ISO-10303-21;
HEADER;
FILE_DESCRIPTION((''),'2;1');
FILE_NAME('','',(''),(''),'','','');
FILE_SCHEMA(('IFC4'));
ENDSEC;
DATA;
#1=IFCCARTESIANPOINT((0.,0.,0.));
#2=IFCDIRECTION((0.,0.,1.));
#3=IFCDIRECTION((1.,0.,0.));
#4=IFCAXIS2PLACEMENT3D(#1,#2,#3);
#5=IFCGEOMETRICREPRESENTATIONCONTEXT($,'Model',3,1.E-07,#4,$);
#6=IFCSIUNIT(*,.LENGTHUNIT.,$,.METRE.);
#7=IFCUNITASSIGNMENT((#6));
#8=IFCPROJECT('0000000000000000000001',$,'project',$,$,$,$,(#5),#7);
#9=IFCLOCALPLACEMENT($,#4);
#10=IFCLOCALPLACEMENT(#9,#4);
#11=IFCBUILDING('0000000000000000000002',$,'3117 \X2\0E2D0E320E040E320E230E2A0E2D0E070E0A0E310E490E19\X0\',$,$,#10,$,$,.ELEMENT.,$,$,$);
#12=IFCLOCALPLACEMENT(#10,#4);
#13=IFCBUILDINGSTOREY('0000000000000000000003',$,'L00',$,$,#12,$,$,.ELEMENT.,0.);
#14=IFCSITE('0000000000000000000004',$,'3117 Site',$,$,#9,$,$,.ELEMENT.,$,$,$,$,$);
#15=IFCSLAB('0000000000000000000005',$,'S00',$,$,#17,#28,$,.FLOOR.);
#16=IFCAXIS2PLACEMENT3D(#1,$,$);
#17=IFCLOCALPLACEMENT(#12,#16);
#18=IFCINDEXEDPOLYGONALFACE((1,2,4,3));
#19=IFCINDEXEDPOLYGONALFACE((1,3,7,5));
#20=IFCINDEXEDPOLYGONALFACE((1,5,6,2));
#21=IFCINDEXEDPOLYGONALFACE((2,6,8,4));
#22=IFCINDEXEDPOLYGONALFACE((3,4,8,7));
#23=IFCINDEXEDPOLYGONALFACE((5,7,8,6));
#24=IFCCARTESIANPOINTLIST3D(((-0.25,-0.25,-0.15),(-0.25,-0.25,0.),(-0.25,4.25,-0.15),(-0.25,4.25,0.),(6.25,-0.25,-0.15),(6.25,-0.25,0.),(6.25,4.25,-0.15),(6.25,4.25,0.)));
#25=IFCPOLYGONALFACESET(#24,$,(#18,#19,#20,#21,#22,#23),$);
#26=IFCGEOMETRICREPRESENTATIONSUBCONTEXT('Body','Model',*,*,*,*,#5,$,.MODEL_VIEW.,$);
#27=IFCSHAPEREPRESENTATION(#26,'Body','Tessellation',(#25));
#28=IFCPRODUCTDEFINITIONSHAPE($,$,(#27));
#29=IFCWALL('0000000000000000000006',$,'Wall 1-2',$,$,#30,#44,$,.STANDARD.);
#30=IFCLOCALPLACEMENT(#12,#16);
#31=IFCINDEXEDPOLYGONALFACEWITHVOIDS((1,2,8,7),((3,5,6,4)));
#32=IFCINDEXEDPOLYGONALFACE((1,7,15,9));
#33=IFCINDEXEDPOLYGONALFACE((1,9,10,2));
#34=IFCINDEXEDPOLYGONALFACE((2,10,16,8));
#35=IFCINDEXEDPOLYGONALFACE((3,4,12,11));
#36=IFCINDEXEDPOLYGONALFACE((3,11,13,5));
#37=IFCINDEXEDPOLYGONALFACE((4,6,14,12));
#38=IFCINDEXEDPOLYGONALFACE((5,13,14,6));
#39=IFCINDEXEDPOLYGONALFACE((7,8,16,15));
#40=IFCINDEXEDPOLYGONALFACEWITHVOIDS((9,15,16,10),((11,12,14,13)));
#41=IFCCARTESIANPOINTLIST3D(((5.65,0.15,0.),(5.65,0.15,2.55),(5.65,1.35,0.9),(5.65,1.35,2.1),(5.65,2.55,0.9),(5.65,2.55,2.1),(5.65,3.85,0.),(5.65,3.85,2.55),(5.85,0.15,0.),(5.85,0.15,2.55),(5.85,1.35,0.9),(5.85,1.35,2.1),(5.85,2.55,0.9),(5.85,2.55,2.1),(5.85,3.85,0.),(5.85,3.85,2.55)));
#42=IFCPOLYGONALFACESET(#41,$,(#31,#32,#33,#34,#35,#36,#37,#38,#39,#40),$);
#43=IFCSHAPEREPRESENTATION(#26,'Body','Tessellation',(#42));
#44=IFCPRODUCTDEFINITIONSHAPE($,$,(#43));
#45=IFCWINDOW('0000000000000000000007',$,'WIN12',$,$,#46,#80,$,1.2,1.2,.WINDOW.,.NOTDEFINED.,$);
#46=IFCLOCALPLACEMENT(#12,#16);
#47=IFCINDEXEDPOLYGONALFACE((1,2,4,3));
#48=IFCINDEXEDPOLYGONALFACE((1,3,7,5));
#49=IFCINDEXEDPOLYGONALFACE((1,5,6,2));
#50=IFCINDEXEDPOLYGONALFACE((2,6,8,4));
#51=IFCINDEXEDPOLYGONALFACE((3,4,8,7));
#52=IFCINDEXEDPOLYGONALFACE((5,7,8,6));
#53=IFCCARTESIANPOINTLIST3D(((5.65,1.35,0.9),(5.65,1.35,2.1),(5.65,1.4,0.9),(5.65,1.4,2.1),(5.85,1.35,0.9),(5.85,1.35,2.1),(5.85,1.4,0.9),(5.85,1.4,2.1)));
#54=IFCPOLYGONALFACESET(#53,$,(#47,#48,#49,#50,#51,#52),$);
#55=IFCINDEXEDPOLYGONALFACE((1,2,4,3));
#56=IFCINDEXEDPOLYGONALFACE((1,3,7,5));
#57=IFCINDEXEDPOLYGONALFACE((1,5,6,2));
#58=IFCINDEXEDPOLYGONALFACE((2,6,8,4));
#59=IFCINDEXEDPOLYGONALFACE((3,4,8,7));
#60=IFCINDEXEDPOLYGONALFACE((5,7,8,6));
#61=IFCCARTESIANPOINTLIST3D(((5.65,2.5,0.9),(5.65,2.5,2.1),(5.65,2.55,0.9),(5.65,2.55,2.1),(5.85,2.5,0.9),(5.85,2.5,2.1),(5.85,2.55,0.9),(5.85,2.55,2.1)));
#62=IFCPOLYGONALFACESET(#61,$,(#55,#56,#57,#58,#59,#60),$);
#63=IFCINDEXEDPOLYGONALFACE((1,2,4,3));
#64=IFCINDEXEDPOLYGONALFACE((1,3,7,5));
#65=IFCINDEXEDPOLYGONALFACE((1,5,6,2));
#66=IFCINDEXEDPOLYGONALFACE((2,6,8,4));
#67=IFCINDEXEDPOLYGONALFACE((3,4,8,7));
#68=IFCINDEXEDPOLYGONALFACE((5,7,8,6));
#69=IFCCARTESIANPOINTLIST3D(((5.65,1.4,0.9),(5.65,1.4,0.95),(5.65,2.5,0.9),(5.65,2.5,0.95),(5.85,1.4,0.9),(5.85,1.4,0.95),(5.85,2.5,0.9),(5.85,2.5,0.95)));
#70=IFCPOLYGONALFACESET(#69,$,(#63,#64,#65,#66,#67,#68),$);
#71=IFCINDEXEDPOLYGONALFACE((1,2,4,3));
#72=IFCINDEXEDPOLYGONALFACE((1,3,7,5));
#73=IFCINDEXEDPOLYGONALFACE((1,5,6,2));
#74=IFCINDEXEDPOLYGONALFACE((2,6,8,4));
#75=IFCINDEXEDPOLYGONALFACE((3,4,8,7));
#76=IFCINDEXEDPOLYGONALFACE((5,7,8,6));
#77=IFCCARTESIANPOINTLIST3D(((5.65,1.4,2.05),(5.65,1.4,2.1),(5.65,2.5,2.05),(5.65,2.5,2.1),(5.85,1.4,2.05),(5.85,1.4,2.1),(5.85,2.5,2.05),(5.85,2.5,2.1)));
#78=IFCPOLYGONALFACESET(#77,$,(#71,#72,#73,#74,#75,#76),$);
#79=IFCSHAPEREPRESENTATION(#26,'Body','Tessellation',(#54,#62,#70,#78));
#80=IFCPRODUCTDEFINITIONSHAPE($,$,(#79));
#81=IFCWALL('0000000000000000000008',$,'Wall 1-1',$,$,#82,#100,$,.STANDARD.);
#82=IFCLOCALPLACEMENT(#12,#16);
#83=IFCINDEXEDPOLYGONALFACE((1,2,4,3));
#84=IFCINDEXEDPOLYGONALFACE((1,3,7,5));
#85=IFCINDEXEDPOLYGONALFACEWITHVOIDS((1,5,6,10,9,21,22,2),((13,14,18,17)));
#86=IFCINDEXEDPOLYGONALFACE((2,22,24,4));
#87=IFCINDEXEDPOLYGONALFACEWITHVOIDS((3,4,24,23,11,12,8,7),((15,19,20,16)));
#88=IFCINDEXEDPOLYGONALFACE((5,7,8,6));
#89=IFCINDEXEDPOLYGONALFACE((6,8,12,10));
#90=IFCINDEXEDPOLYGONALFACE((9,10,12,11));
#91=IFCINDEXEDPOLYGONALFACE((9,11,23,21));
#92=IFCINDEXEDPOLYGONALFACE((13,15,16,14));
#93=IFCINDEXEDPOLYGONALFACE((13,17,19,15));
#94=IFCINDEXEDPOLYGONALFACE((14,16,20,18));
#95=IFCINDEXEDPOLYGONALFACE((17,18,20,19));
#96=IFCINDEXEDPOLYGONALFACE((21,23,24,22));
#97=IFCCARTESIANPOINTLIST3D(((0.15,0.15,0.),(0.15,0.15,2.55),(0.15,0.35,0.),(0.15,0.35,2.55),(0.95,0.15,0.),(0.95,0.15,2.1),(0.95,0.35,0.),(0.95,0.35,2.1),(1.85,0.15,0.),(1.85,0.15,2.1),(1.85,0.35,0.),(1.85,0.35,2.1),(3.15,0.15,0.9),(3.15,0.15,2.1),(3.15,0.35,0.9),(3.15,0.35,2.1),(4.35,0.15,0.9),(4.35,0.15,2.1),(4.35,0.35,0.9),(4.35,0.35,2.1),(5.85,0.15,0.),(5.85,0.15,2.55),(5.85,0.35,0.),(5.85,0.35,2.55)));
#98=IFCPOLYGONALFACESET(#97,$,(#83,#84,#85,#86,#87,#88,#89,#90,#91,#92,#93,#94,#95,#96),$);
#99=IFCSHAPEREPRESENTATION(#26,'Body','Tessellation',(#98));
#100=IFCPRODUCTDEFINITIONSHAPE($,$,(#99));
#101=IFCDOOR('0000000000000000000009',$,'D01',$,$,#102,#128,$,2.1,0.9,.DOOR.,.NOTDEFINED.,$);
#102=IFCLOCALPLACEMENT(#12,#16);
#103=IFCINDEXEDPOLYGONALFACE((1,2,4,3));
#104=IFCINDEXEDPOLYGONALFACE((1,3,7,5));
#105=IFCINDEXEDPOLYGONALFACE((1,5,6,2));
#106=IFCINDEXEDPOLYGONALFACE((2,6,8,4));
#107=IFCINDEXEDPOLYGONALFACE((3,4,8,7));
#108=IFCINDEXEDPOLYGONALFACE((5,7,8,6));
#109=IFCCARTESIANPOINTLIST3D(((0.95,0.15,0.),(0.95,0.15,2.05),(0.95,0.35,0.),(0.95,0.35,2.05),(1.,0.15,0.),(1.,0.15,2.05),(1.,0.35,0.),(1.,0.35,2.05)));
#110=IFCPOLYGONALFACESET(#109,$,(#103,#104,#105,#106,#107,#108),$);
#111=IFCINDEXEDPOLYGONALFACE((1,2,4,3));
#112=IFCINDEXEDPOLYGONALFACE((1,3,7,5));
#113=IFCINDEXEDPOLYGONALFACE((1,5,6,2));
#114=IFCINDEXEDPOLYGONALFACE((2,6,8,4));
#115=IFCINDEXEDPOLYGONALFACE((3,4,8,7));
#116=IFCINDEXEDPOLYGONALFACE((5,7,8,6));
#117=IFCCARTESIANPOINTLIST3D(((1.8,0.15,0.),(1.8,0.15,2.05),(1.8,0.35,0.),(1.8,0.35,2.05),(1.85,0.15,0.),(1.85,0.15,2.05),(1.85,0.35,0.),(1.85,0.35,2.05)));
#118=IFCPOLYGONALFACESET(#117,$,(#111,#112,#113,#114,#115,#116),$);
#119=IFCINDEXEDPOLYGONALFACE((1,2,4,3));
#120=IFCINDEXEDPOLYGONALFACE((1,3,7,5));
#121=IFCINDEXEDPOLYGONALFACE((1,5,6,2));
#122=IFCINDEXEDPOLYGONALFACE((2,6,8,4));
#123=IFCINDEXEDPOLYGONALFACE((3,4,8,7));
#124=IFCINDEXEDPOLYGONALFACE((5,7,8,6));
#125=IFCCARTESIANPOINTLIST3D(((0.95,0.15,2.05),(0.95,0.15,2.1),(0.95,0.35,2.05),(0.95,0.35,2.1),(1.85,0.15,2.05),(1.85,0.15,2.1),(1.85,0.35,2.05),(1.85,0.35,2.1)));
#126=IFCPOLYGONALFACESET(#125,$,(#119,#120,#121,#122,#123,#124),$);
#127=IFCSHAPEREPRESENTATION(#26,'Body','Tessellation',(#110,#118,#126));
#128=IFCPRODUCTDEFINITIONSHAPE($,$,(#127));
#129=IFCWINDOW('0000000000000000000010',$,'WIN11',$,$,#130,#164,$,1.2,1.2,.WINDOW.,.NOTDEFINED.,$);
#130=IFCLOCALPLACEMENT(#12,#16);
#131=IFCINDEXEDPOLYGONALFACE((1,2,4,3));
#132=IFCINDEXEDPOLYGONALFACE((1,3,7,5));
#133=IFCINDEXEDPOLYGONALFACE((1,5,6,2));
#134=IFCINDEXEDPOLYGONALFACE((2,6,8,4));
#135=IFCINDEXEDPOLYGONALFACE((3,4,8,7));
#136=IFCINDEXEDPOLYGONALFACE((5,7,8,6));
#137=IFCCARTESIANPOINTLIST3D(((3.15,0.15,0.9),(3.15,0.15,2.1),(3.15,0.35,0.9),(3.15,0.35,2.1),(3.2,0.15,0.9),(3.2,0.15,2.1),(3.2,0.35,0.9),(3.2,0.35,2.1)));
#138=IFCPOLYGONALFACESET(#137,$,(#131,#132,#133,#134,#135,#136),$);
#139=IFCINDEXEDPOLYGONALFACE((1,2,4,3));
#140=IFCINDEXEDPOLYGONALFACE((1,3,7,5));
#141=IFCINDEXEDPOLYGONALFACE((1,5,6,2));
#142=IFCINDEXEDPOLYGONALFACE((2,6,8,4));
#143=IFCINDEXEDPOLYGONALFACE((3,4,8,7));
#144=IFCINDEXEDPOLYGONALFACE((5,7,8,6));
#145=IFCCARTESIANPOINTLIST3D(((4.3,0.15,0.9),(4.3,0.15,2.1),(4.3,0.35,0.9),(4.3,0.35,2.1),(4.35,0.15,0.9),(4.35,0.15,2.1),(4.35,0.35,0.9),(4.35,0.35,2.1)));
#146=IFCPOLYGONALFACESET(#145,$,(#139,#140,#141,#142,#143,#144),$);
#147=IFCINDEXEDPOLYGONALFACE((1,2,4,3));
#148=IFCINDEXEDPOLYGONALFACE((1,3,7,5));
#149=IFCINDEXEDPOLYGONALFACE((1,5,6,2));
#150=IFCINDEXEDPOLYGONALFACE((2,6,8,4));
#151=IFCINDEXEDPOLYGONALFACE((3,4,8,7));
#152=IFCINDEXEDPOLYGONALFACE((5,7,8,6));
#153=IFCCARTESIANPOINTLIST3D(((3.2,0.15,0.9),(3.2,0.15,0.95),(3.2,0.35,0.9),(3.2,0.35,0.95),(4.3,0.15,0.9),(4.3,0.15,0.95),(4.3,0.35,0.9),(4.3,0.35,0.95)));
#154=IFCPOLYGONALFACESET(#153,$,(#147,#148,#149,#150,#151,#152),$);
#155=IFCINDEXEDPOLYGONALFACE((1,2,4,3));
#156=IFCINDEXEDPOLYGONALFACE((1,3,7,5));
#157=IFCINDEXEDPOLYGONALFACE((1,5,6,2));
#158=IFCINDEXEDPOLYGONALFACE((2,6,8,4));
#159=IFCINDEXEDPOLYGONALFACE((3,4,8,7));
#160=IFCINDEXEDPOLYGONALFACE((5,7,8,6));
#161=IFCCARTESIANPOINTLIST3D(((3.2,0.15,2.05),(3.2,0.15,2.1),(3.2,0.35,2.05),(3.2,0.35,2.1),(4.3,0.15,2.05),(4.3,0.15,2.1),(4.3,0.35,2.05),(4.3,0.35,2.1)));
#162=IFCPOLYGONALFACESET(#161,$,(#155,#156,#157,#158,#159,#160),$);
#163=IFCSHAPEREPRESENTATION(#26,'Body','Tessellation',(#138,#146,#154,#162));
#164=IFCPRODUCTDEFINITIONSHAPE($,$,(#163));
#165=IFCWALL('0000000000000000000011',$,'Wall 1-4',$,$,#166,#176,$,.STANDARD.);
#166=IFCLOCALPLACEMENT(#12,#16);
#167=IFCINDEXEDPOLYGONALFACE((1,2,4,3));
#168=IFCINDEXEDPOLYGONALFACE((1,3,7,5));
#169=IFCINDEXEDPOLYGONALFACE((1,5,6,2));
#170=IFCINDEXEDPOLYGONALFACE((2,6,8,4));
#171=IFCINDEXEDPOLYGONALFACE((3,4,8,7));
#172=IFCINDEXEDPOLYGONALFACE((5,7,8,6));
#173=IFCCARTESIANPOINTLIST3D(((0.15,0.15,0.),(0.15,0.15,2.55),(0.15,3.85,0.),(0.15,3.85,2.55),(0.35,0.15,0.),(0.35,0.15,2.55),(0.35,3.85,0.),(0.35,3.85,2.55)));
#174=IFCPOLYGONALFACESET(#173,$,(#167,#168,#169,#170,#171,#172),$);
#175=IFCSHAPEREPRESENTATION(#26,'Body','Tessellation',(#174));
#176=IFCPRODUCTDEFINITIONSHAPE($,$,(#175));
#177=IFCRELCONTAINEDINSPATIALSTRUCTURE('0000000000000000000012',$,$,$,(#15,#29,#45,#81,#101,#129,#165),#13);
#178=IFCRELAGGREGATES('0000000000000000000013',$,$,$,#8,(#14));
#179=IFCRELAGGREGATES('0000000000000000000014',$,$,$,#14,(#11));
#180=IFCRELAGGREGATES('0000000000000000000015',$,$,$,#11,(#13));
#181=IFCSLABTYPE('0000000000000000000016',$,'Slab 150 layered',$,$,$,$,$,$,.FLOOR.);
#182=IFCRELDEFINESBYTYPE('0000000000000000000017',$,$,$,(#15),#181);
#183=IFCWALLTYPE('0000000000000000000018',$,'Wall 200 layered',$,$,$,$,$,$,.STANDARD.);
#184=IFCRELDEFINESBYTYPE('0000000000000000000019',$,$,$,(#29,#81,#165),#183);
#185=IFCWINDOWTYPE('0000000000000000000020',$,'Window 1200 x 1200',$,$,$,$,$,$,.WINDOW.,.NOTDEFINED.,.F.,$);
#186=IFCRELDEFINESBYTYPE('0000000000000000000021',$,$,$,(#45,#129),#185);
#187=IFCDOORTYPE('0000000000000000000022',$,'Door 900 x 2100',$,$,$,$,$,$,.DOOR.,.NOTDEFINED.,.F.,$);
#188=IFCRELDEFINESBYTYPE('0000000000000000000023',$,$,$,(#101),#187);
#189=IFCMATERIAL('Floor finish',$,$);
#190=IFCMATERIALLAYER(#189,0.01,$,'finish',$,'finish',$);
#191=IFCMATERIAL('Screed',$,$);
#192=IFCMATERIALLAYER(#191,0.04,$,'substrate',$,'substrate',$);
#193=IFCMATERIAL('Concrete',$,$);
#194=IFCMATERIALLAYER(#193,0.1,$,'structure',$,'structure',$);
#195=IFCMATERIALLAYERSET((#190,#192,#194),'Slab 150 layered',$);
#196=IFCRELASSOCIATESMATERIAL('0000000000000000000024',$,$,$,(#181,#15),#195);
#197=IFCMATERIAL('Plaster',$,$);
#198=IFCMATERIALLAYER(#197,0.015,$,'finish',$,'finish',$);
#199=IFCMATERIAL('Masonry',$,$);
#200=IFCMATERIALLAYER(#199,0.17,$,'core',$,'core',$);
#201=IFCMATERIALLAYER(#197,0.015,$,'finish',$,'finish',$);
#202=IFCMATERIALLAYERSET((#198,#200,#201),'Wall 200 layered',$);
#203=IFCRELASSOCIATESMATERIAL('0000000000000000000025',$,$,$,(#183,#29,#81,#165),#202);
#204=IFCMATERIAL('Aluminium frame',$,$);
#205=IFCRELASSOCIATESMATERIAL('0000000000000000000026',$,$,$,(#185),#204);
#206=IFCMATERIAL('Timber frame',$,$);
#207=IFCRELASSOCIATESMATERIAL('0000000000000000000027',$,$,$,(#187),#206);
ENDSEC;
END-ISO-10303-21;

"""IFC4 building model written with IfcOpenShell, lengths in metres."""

from ifc_helpers import new_model, si_unit, frame, origin_with_axes, place, context, subcontext, project, spatial, polyline, outline, extrude, material, layer, layer_set, layer_usage, type_object, element, fill, save


model = new_model("IFC4")

# Units and contexts
model_context = context("Model", 3, precision=1e-07, world=origin_with_axes())
body_context = subcontext(model_context, "Body", "Model", "MODEL_VIEW")
ifc_project = project(units=[si_unit("LENGTHUNIT", "METRE")], contexts=[model_context])

# Site, building, storey
site_placement = place(None, origin_with_axes())
site = spatial("IfcSite", under=ifc_project, at=site_placement, Name="3117 Site", CompositionType="ELEMENT")
building_placement = place(site_placement, origin_with_axes())
building = spatial("IfcBuilding", under=site, at=building_placement, Name="3117 อาคารสองชั้น", CompositionType="ELEMENT")
storey_placement = place(building_placement, origin_with_axes())
storey = spatial("IfcBuildingStorey", under=building, at=storey_placement, Name="L00", CompositionType="ELEMENT", Elevation=0.0)

# Shared definitions
ifc_material_1 = material(Name="Concrete")

# Slab
ifc_material_2 = material(Name="Floor finish")
ifc_layer_1 = layer(ifc_material_2, 0.01, Name="finish", Category="finish")
ifc_material_3 = material(Name="Screed")
ifc_layer_2 = layer(ifc_material_3, 0.04, Name="substrate", Category="substrate")
ifc_layer_3 = layer(ifc_material_1, 0.1, Name="structure", Category="structure")
ifc_layer_set_1 = layer_set([ifc_layer_1, ifc_layer_2, ifc_layer_3], Name="Slab 150 layered")
ifc_layer_usage_1 = layer_usage(ifc_layer_set_1, "AXIS3", "NEGATIVE", 0.15)
slab_type = type_object("IfcSlabType", Name="Slab 150 layered", PredefinedType="FLOOR", material=ifc_layer_set_1)
slab_placement = place(storey_placement, frame((0.0, 0.0, -0.15), z_axis=(0.0, 0.0, 1.0), x_axis=(1.0, 0.0, 0.0)))
element("IfcSlab", 1, at=slab_placement, inside=storey, type_object=slab_type, material=ifc_layer_usage_1, Name="S00", PredefinedType="FLOOR", context=body_context, shape_type="SweptSolid", body=[
    extrude(outline(polyline([(-0.25, -0.25), (6.25, -0.25), (6.25, 4.25), (-0.25, 4.25), (-0.25, -0.25)])), origin_with_axes(), (0.0, 0.0, 1.0), 0.15),
])

# Wall, opening, window
ifc_material_4 = material(Name="Plaster")
ifc_layer_4 = layer(ifc_material_4, 0.015, Name="finish", Category="finish")
ifc_material_5 = material(Name="Masonry")
ifc_layer_5 = layer(ifc_material_5, 0.17, Name="core", Category="core")
ifc_layer_6 = layer(ifc_material_4, 0.015, Name="finish", Category="finish")
ifc_layer_set_2 = layer_set([ifc_layer_4, ifc_layer_5, ifc_layer_6], Name="Wall 200 layered")
ifc_layer_usage_2 = layer_usage(ifc_layer_set_2, "AXIS2", "POSITIVE", 0.0)
wall_type = type_object("IfcWallType", Name="Wall 200 layered", PredefinedType="STANDARD", material=ifc_layer_set_2)
wall_1_placement = place(storey_placement, frame((5.85, 0.15, 0.0), z_axis=(0.0, 0.0, 1.0), x_axis=(0.0, 1.0, 0.0)))
wall_1 = element("IfcWall", 2, at=wall_1_placement, inside=storey, type_object=wall_type, material=ifc_layer_usage_2, Name="Wall 1-2", PredefinedType="STANDARD", context=body_context, shape_type="SweptSolid", body=[
    extrude(outline(polyline([(0.0, 0.0), (3.7, 0.0), (3.7, 0.2), (0.0, 0.2), (0.0, 0.0)])), origin_with_axes(), (0.0, 0.0, 1.0), 2.55),
])
opening_1_placement = place(wall_1_placement, frame((1.2, 0.0, 0.9), z_axis=(0.0, 0.0, 1.0), x_axis=(1.0, 0.0, 0.0)))
opening_1 = element("IfcOpeningElement", 3, at=opening_1_placement, cuts=wall_1, PredefinedType="OPENING", context=body_context, shape_type="SweptSolid", body=[
    extrude(outline(polyline([(0.0, 0.0), (1.2, 0.0), (1.2, 0.2), (0.0, 0.2), (0.0, 0.0)])), origin_with_axes(), (0.0, 0.0, 1.0), 1.2),
])
ifc_material_6 = material(Name="Aluminium frame")
window_type = type_object("IfcWindowType", Name="Window 1200 x 1200", ParameterTakesPrecedence=False, PartitioningType="NOTDEFINED", PredefinedType="WINDOW", material=ifc_material_6)
window_1_placement = place(opening_1_placement, frame((0.0, 0.0, 0.0), z_axis=(0.0, 0.0, 1.0), x_axis=(1.0, 0.0, 0.0)))
window_1 = element("IfcWindow", 4, at=window_1_placement, inside=storey, type_object=window_type, Name="WIN12", OverallHeight=1.2, OverallWidth=1.2, PartitioningType="NOTDEFINED", PredefinedType="WINDOW", context=body_context, shape_type="SweptSolid", body=[
    extrude(outline(polyline([(0.0, 0.0), (0.05, 0.0), (0.05, 0.2), (0.0, 0.2), (0.0, 0.0)])), origin_with_axes(), (0.0, 0.0, 1.0), 1.2),
    extrude(outline(polyline([(0.0, 0.0), (0.05, 0.0), (0.05, 0.2), (0.0, 0.2), (0.0, 0.0)])), frame((1.15, 0.0, 0.0), z_axis=(0.0, 0.0, 1.0), x_axis=(1.0, 0.0, 0.0)), (0.0, 0.0, 1.0), 1.2),
    extrude(outline(polyline([(0.0, 0.0), (1.1, 0.0), (1.1, 0.2), (0.0, 0.2), (0.0, 0.0)])), frame((0.05, 0.0, 0.0), z_axis=(0.0, 0.0, 1.0), x_axis=(1.0, 0.0, 0.0)), (0.0, 0.0, 1.0), 0.05),
    extrude(outline(polyline([(0.0, 0.0), (1.1, 0.0), (1.1, 0.2), (0.0, 0.2), (0.0, 0.0)])), frame((0.05, 0.0, 1.15), z_axis=(0.0, 0.0, 1.0), x_axis=(1.0, 0.0, 0.0)), (0.0, 0.0, 1.0), 0.05),
])
fill(opening_1, window_1)

# Wall, openings, door, window
ifc_layer_usage_3 = layer_usage(ifc_layer_set_2, "AXIS2", "POSITIVE", 0.0)
wall_2_placement = place(storey_placement, frame((0.15, 0.15, 0.0), z_axis=(0.0, 0.0, 1.0), x_axis=(1.0, 0.0, 0.0)))
wall_2 = element("IfcWall", 5, at=wall_2_placement, inside=storey, type_object=wall_type, material=ifc_layer_usage_3, Name="Wall 1-1", PredefinedType="STANDARD", context=body_context, shape_type="SweptSolid", body=[
    extrude(outline(polyline([(0.0, 0.0), (5.7, 0.0), (5.7, 0.2), (0.0, 0.2), (0.0, 0.0)])), origin_with_axes(), (0.0, 0.0, 1.0), 2.55),
])
opening_2_placement = place(wall_2_placement, frame((0.8, 0.0, 0.0), z_axis=(0.0, 0.0, 1.0), x_axis=(1.0, 0.0, 0.0)))
opening_2 = element("IfcOpeningElement", 6, at=opening_2_placement, cuts=wall_2, PredefinedType="OPENING", context=body_context, shape_type="SweptSolid", body=[
    extrude(outline(polyline([(0.0, 0.0), (0.9, 0.0), (0.9, 0.2), (0.0, 0.2), (0.0, 0.0)])), origin_with_axes(), (0.0, 0.0, 1.0), 2.1),
])
opening_3_placement = place(wall_2_placement, frame((3.0, 0.0, 0.9), z_axis=(0.0, 0.0, 1.0), x_axis=(1.0, 0.0, 0.0)))
opening_3 = element("IfcOpeningElement", 7, at=opening_3_placement, cuts=wall_2, PredefinedType="OPENING", context=body_context, shape_type="SweptSolid", body=[
    extrude(outline(polyline([(0.0, 0.0), (1.2, 0.0), (1.2, 0.2), (0.0, 0.2), (0.0, 0.0)])), origin_with_axes(), (0.0, 0.0, 1.0), 1.2),
])
ifc_material_7 = material(Name="Timber frame")
door_type = type_object("IfcDoorType", Name="Door 900 x 2100", OperationType="NOTDEFINED", ParameterTakesPrecedence=False, PredefinedType="DOOR", material=ifc_material_7)
door_placement = place(opening_2_placement, frame((0.0, 0.0, 0.0), z_axis=(0.0, 0.0, 1.0), x_axis=(1.0, 0.0, 0.0)))
door = element("IfcDoor", 8, at=door_placement, inside=storey, type_object=door_type, Name="D01", OperationType="NOTDEFINED", OverallHeight=2.1, OverallWidth=0.9, PredefinedType="DOOR", context=body_context, shape_type="SweptSolid", body=[
    extrude(outline(polyline([(0.0, 0.0), (0.05, 0.0), (0.05, 0.2), (0.0, 0.2), (0.0, 0.0)])), origin_with_axes(), (0.0, 0.0, 1.0), 2.05),
    extrude(outline(polyline([(0.0, 0.0), (0.05, 0.0), (0.05, 0.2), (0.0, 0.2), (0.0, 0.0)])), frame((0.85, 0.0, 0.0), z_axis=(0.0, 0.0, 1.0), x_axis=(1.0, 0.0, 0.0)), (0.0, 0.0, 1.0), 2.05),
    extrude(outline(polyline([(0.0, 0.0), (0.9, 0.0), (0.9, 0.2), (0.0, 0.2), (0.0, 0.0)])), frame((0.0, 0.0, 2.05), z_axis=(0.0, 0.0, 1.0), x_axis=(1.0, 0.0, 0.0)), (0.0, 0.0, 1.0), 0.05),
])
fill(opening_2, door)
window_2_placement = place(opening_3_placement, frame((0.0, 0.0, 0.0), z_axis=(0.0, 0.0, 1.0), x_axis=(1.0, 0.0, 0.0)))
window_2 = element("IfcWindow", 9, at=window_2_placement, inside=storey, type_object=window_type, Name="WIN11", OverallHeight=1.2, OverallWidth=1.2, PartitioningType="NOTDEFINED", PredefinedType="WINDOW", context=body_context, shape_type="SweptSolid", body=[
    extrude(outline(polyline([(0.0, 0.0), (0.05, 0.0), (0.05, 0.2), (0.0, 0.2), (0.0, 0.0)])), origin_with_axes(), (0.0, 0.0, 1.0), 1.2),
    extrude(outline(polyline([(0.0, 0.0), (0.05, 0.0), (0.05, 0.2), (0.0, 0.2), (0.0, 0.0)])), frame((1.15, 0.0, 0.0), z_axis=(0.0, 0.0, 1.0), x_axis=(1.0, 0.0, 0.0)), (0.0, 0.0, 1.0), 1.2),
    extrude(outline(polyline([(0.0, 0.0), (1.1, 0.0), (1.1, 0.2), (0.0, 0.2), (0.0, 0.0)])), frame((0.05, 0.0, 0.0), z_axis=(0.0, 0.0, 1.0), x_axis=(1.0, 0.0, 0.0)), (0.0, 0.0, 1.0), 0.05),
    extrude(outline(polyline([(0.0, 0.0), (1.1, 0.0), (1.1, 0.2), (0.0, 0.2), (0.0, 0.0)])), frame((0.05, 0.0, 1.15), z_axis=(0.0, 0.0, 1.0), x_axis=(1.0, 0.0, 0.0)), (0.0, 0.0, 1.0), 0.05),
])
fill(opening_3, window_2)

# Wall
ifc_layer_usage_4 = layer_usage(ifc_layer_set_2, "AXIS2", "POSITIVE", 0.0)
wall_3_placement = place(storey_placement, frame((0.15, 3.85, 0.0), z_axis=(0.0, 0.0, 1.0), x_axis=(0.0, -1.0, 0.0)))
element("IfcWall", 10, at=wall_3_placement, inside=storey, type_object=wall_type, material=ifc_layer_usage_4, Name="Wall 1-4", PredefinedType="STANDARD", context=body_context, shape_type="SweptSolid", body=[
    extrude(outline(polyline([(0.0, 0.0), (3.7, 0.0), (3.7, 0.2), (0.0, 0.2), (0.0, 0.0)])), origin_with_axes(), (0.0, 0.0, 1.0), 2.55),
])

save(model, "model.ifc")
